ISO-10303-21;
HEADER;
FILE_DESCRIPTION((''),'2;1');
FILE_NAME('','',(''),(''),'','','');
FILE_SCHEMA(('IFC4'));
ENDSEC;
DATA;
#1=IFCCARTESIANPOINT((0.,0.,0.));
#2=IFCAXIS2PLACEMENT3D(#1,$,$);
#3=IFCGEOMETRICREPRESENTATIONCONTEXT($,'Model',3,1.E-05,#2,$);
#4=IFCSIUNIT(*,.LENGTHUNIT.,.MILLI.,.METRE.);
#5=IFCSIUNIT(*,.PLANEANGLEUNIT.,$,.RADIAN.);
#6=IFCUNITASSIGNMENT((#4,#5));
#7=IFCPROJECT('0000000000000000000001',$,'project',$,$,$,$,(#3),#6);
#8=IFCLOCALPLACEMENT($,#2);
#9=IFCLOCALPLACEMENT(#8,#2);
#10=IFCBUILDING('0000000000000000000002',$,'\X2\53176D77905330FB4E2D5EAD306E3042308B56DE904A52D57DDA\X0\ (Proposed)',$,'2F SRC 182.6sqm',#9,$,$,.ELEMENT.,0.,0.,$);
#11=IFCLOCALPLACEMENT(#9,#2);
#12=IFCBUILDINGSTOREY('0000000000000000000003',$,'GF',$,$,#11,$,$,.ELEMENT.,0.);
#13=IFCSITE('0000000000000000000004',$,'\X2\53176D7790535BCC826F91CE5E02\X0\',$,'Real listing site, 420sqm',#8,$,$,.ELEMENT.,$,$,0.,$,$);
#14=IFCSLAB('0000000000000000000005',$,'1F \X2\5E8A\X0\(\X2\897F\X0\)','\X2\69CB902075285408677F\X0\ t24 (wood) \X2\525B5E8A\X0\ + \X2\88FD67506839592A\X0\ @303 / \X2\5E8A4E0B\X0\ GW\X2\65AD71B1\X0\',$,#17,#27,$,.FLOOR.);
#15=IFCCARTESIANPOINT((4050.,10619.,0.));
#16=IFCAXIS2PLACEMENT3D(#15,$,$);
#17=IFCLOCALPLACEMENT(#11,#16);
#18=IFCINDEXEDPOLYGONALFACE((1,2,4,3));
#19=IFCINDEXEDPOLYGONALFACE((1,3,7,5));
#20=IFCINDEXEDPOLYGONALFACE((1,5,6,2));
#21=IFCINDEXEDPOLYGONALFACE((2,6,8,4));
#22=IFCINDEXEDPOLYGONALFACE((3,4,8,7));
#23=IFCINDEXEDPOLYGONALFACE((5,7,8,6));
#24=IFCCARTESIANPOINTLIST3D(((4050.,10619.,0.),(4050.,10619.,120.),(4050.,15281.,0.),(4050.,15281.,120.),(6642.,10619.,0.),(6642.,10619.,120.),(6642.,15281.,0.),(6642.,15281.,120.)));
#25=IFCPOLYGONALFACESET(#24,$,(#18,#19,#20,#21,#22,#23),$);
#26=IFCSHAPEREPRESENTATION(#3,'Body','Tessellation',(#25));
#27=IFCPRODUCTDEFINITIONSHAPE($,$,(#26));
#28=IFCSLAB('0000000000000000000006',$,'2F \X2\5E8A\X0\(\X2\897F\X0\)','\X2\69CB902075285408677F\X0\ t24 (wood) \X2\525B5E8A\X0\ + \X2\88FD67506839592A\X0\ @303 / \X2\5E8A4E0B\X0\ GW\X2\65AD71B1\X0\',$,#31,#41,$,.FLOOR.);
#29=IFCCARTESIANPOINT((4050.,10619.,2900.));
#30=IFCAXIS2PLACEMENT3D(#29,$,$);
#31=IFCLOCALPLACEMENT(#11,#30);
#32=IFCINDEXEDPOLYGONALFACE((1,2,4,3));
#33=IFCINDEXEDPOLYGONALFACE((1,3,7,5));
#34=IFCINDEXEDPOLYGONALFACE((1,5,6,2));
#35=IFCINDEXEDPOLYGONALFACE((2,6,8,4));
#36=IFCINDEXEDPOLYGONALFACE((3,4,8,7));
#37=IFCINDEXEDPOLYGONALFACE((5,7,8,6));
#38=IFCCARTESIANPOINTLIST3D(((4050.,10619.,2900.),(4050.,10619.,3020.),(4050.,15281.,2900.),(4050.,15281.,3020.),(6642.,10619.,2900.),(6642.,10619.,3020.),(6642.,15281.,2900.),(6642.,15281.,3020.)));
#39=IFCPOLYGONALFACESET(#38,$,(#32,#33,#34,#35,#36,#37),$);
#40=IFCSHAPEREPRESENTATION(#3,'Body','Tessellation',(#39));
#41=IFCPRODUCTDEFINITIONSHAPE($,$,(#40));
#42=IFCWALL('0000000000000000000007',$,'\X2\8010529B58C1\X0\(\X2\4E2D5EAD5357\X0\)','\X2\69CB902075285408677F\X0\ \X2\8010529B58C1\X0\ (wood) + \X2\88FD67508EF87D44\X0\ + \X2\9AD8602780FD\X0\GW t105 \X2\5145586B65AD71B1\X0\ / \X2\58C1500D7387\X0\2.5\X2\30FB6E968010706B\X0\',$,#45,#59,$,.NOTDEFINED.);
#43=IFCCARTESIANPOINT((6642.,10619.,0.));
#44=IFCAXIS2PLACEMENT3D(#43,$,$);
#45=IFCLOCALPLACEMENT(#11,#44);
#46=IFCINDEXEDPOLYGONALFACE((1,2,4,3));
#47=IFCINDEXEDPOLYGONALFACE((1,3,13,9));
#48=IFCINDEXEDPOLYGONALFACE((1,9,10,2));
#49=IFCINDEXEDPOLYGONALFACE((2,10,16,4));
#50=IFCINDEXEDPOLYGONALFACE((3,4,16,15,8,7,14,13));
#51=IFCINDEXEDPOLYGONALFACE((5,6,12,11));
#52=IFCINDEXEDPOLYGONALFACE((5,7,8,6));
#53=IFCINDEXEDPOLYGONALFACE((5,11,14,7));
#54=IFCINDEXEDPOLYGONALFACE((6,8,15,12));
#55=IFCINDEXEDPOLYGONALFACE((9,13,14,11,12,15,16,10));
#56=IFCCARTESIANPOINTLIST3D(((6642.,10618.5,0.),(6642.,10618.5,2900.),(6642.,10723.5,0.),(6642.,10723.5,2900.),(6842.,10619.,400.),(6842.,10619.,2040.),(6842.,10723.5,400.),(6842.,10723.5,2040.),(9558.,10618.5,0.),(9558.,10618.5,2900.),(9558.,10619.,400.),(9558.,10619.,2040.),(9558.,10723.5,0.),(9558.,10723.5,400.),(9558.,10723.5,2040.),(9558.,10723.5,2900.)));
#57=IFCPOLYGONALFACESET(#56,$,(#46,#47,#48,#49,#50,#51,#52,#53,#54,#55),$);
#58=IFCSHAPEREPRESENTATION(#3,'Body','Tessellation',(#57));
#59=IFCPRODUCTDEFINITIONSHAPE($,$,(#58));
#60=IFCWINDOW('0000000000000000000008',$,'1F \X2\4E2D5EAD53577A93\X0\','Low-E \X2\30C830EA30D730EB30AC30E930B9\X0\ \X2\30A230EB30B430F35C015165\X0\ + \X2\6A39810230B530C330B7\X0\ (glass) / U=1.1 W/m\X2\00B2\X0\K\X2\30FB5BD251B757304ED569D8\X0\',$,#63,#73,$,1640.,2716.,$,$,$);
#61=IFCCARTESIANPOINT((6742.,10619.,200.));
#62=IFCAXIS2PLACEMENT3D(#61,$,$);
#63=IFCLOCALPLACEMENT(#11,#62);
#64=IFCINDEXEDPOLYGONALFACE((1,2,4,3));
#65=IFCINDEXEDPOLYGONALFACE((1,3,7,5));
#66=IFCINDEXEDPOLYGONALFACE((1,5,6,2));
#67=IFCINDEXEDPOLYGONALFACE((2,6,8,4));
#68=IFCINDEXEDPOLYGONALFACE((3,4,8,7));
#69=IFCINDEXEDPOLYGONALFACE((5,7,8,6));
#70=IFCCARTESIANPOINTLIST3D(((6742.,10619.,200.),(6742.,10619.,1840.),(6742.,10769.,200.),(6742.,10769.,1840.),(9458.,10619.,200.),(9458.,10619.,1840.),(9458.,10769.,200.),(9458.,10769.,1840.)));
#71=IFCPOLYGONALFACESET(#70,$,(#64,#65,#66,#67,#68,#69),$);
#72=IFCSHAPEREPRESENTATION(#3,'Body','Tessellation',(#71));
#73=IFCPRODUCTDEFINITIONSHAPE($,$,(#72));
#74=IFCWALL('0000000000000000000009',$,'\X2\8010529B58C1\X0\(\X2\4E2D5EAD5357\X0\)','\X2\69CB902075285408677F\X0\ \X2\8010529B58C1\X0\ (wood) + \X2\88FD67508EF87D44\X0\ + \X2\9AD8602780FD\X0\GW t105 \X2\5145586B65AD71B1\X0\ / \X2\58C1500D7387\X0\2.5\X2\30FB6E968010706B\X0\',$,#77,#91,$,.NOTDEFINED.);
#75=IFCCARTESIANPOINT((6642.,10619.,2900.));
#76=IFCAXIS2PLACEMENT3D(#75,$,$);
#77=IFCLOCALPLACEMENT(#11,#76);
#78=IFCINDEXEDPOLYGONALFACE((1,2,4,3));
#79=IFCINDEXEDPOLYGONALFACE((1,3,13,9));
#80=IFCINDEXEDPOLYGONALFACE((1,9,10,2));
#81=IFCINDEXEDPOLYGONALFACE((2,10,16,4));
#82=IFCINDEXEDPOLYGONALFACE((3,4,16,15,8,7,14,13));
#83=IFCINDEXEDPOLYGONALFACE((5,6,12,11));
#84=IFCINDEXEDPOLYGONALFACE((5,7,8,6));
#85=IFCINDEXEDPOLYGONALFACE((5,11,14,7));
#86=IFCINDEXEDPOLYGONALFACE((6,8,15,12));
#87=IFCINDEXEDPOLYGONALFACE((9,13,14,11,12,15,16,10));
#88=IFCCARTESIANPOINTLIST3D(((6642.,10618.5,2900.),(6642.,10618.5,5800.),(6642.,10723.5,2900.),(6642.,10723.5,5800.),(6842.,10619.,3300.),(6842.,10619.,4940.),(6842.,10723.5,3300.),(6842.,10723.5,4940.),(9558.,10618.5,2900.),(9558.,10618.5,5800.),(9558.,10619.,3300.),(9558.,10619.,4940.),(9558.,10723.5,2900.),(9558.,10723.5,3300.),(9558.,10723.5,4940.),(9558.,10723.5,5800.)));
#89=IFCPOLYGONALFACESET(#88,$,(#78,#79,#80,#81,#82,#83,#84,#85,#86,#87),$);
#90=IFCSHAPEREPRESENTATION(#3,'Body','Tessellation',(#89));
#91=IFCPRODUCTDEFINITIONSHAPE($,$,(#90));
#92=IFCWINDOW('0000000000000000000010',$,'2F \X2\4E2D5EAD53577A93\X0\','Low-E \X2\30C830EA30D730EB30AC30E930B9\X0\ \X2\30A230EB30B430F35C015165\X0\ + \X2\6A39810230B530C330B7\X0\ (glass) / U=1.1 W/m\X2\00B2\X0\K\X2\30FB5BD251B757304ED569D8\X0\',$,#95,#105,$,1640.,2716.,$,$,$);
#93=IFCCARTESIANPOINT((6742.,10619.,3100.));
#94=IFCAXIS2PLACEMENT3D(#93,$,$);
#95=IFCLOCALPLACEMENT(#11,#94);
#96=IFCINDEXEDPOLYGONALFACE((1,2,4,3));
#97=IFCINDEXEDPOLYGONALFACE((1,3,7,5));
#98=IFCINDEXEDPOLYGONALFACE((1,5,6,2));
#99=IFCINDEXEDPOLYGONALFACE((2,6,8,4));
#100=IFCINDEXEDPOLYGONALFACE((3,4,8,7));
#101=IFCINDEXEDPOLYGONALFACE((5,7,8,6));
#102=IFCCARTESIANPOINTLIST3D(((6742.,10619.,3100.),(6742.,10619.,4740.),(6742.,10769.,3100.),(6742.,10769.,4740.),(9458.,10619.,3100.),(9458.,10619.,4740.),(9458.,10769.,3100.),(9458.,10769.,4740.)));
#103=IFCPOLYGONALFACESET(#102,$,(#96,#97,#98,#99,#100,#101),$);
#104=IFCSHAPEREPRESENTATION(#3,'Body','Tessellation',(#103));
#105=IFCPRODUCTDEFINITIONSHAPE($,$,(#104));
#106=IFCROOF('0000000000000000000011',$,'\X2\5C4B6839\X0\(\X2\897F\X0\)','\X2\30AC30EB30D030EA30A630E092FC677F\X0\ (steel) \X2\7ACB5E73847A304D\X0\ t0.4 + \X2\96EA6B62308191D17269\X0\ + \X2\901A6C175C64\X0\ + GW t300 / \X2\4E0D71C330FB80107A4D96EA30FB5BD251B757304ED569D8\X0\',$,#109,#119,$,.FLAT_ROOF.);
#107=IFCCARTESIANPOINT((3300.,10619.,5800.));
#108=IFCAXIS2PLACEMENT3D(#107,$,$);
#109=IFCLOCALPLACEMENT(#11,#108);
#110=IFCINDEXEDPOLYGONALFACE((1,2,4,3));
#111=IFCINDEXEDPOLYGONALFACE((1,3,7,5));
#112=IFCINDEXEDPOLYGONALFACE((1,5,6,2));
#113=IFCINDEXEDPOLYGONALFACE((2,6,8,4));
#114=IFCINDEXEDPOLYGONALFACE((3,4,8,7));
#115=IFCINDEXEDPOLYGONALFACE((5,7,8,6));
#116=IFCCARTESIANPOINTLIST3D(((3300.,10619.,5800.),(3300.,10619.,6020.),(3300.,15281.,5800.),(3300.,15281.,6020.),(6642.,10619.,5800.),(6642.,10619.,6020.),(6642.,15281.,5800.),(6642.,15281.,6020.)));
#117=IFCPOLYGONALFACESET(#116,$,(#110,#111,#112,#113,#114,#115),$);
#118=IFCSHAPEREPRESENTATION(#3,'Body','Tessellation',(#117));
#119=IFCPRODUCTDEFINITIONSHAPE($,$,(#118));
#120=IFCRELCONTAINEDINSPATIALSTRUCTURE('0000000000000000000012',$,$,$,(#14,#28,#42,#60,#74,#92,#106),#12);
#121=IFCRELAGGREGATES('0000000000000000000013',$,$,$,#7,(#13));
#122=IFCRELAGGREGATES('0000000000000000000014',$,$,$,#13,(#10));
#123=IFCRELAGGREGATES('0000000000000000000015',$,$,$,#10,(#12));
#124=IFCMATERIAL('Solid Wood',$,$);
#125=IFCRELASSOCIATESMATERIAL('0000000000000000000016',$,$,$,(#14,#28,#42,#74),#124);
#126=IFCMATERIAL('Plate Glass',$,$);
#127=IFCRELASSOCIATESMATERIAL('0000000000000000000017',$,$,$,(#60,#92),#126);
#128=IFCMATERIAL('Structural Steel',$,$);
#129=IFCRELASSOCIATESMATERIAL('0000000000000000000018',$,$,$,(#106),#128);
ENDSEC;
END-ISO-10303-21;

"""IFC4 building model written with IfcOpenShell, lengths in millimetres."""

from ifc_helpers import new_model, si_unit, frame, frame_2d, origin, place, context, project, spatial, rectangle, extrude, material, element, fill, save


model = new_model("IFC4")

# Units and contexts
model_context = context("Model", 3, precision=1e-05, world=origin())
ifc_project = project(units=[si_unit("LENGTHUNIT", "METRE", prefix="MILLI"), si_unit("PLANEANGLEUNIT", "RADIAN")], contexts=[model_context])

# Site, building, storey
site_placement = place(None, origin())
site = spatial("IfcSite", under=ifc_project, at=site_placement, Name="北海道富良野市", ObjectType="Real listing site, 420sqm", CompositionType="ELEMENT", RefElevation=0.0)
building_placement = place(site_placement, origin())
building = spatial("IfcBuilding", under=site, at=building_placement, Name="北海道・中庭のある回遊動線 (Proposed)", ObjectType="2F SRC 182.6sqm", CompositionType="ELEMENT", ElevationOfRefHeight=0.0, ElevationOfTerrain=0.0)
storey_placement = place(building_placement, origin())
storey = spatial("IfcBuildingStorey", under=building, at=storey_placement, Name="GF", CompositionType="ELEMENT", Elevation=0.0)

# Shared definitions
ifc_material_1 = material(Name="Solid Wood")

# Slabs
slab_1_placement = place(storey_placement, frame((4050.0, 10619.0, 0.0)))
element("IfcSlab", 1, at=slab_1_placement, inside=storey, material=ifc_material_1, Name="1F 床(西)", Description="構造用合板 t24 (wood) 剛床 + 製材根太 @303 / 床下 GW断熱", PredefinedType="FLOOR", context=model_context, shape_type="SweptSolid", body=[
    extrude(rectangle(XDim=2592.0, YDim=4662.0, at=frame_2d((1296.0, 2331.0))), frame((4050.0, 10619.0, 0.0)), (0.0, 0.0, 1.0), 120.0),
])
slab_2_placement = place(storey_placement, frame((4050.0, 10619.0, 2900.0)))
element("IfcSlab", 2, at=slab_2_placement, inside=storey, material=ifc_material_1, Name="2F 床(西)", Description="構造用合板 t24 (wood) 剛床 + 製材根太 @303 / 床下 GW断熱", PredefinedType="FLOOR", context=model_context, shape_type="SweptSolid", body=[
    extrude(rectangle(XDim=2592.0, YDim=4662.0, at=frame_2d((1296.0, 2331.0))), frame((4050.0, 10619.0, 2900.0)), (0.0, 0.0, 1.0), 120.0),
])

# Wall, opening, window
wall_1_placement = place(storey_placement, frame((6642.0, 10619.0, 0.0)))
wall_1 = element("IfcWall", 3, at=wall_1_placement, inside=storey, material=ifc_material_1, Name="耐力壁(中庭南)", Description="構造用合板 耐力壁 (wood) + 製材軸組 + 高性能GW t105 充填断熱 / 壁倍率2.5・準耐火", PredefinedType="NOTDEFINED", context=model_context, shape_type="SweptSolid", body=[
    extrude(rectangle(XDim=2916.0, YDim=105.0, at=frame_2d((1458.0, 52.0))), frame((6642.0, 10619.0, 0.0)), (0.0, 0.0, 1.0), 2900.0),
])
opening_1_placement = place(storey_placement, frame((6742.0, 10619.0, 200.0)))
opening_1 = element("IfcOpeningElement", 4, at=opening_1_placement, cuts=wall_1, PredefinedType="NOTDEFINED", context=model_context, shape_type="SweptSolid", body=[
    extrude(rectangle(XDim=2716.0, YDim=150.0, at=frame_2d((1358.0, 75.0))), frame((6742.0, 10619.0, 200.0)), (0.0, 0.0, 1.0), 1640.0),
])
ifc_material_2 = material(Name="Plate Glass")
window_1_placement = place(storey_placement, frame((6742.0, 10619.0, 200.0)))
window_1 = element("IfcWindow", 5, at=window_1_placement, inside=storey, material=ifc_material_2, Name="1F 中庭南窓", Description="Low-E トリプルガラス アルゴン封入 + 樹脂サッシ (glass) / U=1.1 W/m²K・寒冷地仕様", OverallHeight=1640.0, OverallWidth=2716.0, context=model_context, shape_type="SweptSolid", body=[
    extrude(rectangle(XDim=2716.0, YDim=150.0, at=frame_2d((1358.0, 75.0))), frame((6742.0, 10619.0, 200.0)), (0.0, 0.0, 1.0), 1640.0),
])
fill(opening_1, window_1)

# Wall, opening, window
wall_2_placement = place(storey_placement, frame((6642.0, 10619.0, 2900.0)))
wall_2 = element("IfcWall", 6, at=wall_2_placement, inside=storey, material=ifc_material_1, Name="耐力壁(中庭南)", Description="構造用合板 耐力壁 (wood) + 製材軸組 + 高性能GW t105 充填断熱 / 壁倍率2.5・準耐火", PredefinedType="NOTDEFINED", context=model_context, shape_type="SweptSolid", body=[
    extrude(rectangle(XDim=2916.0, YDim=105.0, at=frame_2d((1458.0, 52.0))), frame((6642.0, 10619.0, 2900.0)), (0.0, 0.0, 1.0), 2900.0),
])
opening_2_placement = place(storey_placement, frame((6742.0, 10619.0, 3100.0)))
opening_2 = element("IfcOpeningElement", 7, at=opening_2_placement, cuts=wall_2, PredefinedType="NOTDEFINED", context=model_context, shape_type="SweptSolid", body=[
    extrude(rectangle(XDim=2716.0, YDim=150.0, at=frame_2d((1358.0, 75.0))), frame((6742.0, 10619.0, 3100.0)), (0.0, 0.0, 1.0), 1640.0),
])
window_2_placement = place(storey_placement, frame((6742.0, 10619.0, 3100.0)))
window_2 = element("IfcWindow", 8, at=window_2_placement, inside=storey, material=ifc_material_2, Name="2F 中庭南窓", Description="Low-E トリプルガラス アルゴン封入 + 樹脂サッシ (glass) / U=1.1 W/m²K・寒冷地仕様", OverallHeight=1640.0, OverallWidth=2716.0, context=model_context, shape_type="SweptSolid", body=[
    extrude(rectangle(XDim=2716.0, YDim=150.0, at=frame_2d((1358.0, 75.0))), frame((6742.0, 10619.0, 3100.0)), (0.0, 0.0, 1.0), 1640.0),
])
fill(opening_2, window_2)

# Roof
ifc_material_3 = material(Name="Structural Steel")
for number, where, name in (
    (9, (3300.0, 10619.0, 5800.0), "屋根(西)"),
):
    element("IfcRoof", number, at=place(storey_placement, frame(where)), inside=storey, material=ifc_material_3, Name=name, Description="ガルバリウム鋼板 (steel) 立平葺き t0.4 + 雪止め金物 + 通気層 + GW t300 / 不燃・耐積雪・寒冷地仕様", PredefinedType="FLAT_ROOF", context=model_context, shape_type="SweptSolid", body=[
        extrude(rectangle(XDim=3342.0, YDim=4662.0, at=frame_2d((1671.0, 2331.0))), frame((3300.0, 10619.0, 5800.0)), (0.0, 0.0, 1.0), 220.0),
    ])

save(model, "model.ifc")
